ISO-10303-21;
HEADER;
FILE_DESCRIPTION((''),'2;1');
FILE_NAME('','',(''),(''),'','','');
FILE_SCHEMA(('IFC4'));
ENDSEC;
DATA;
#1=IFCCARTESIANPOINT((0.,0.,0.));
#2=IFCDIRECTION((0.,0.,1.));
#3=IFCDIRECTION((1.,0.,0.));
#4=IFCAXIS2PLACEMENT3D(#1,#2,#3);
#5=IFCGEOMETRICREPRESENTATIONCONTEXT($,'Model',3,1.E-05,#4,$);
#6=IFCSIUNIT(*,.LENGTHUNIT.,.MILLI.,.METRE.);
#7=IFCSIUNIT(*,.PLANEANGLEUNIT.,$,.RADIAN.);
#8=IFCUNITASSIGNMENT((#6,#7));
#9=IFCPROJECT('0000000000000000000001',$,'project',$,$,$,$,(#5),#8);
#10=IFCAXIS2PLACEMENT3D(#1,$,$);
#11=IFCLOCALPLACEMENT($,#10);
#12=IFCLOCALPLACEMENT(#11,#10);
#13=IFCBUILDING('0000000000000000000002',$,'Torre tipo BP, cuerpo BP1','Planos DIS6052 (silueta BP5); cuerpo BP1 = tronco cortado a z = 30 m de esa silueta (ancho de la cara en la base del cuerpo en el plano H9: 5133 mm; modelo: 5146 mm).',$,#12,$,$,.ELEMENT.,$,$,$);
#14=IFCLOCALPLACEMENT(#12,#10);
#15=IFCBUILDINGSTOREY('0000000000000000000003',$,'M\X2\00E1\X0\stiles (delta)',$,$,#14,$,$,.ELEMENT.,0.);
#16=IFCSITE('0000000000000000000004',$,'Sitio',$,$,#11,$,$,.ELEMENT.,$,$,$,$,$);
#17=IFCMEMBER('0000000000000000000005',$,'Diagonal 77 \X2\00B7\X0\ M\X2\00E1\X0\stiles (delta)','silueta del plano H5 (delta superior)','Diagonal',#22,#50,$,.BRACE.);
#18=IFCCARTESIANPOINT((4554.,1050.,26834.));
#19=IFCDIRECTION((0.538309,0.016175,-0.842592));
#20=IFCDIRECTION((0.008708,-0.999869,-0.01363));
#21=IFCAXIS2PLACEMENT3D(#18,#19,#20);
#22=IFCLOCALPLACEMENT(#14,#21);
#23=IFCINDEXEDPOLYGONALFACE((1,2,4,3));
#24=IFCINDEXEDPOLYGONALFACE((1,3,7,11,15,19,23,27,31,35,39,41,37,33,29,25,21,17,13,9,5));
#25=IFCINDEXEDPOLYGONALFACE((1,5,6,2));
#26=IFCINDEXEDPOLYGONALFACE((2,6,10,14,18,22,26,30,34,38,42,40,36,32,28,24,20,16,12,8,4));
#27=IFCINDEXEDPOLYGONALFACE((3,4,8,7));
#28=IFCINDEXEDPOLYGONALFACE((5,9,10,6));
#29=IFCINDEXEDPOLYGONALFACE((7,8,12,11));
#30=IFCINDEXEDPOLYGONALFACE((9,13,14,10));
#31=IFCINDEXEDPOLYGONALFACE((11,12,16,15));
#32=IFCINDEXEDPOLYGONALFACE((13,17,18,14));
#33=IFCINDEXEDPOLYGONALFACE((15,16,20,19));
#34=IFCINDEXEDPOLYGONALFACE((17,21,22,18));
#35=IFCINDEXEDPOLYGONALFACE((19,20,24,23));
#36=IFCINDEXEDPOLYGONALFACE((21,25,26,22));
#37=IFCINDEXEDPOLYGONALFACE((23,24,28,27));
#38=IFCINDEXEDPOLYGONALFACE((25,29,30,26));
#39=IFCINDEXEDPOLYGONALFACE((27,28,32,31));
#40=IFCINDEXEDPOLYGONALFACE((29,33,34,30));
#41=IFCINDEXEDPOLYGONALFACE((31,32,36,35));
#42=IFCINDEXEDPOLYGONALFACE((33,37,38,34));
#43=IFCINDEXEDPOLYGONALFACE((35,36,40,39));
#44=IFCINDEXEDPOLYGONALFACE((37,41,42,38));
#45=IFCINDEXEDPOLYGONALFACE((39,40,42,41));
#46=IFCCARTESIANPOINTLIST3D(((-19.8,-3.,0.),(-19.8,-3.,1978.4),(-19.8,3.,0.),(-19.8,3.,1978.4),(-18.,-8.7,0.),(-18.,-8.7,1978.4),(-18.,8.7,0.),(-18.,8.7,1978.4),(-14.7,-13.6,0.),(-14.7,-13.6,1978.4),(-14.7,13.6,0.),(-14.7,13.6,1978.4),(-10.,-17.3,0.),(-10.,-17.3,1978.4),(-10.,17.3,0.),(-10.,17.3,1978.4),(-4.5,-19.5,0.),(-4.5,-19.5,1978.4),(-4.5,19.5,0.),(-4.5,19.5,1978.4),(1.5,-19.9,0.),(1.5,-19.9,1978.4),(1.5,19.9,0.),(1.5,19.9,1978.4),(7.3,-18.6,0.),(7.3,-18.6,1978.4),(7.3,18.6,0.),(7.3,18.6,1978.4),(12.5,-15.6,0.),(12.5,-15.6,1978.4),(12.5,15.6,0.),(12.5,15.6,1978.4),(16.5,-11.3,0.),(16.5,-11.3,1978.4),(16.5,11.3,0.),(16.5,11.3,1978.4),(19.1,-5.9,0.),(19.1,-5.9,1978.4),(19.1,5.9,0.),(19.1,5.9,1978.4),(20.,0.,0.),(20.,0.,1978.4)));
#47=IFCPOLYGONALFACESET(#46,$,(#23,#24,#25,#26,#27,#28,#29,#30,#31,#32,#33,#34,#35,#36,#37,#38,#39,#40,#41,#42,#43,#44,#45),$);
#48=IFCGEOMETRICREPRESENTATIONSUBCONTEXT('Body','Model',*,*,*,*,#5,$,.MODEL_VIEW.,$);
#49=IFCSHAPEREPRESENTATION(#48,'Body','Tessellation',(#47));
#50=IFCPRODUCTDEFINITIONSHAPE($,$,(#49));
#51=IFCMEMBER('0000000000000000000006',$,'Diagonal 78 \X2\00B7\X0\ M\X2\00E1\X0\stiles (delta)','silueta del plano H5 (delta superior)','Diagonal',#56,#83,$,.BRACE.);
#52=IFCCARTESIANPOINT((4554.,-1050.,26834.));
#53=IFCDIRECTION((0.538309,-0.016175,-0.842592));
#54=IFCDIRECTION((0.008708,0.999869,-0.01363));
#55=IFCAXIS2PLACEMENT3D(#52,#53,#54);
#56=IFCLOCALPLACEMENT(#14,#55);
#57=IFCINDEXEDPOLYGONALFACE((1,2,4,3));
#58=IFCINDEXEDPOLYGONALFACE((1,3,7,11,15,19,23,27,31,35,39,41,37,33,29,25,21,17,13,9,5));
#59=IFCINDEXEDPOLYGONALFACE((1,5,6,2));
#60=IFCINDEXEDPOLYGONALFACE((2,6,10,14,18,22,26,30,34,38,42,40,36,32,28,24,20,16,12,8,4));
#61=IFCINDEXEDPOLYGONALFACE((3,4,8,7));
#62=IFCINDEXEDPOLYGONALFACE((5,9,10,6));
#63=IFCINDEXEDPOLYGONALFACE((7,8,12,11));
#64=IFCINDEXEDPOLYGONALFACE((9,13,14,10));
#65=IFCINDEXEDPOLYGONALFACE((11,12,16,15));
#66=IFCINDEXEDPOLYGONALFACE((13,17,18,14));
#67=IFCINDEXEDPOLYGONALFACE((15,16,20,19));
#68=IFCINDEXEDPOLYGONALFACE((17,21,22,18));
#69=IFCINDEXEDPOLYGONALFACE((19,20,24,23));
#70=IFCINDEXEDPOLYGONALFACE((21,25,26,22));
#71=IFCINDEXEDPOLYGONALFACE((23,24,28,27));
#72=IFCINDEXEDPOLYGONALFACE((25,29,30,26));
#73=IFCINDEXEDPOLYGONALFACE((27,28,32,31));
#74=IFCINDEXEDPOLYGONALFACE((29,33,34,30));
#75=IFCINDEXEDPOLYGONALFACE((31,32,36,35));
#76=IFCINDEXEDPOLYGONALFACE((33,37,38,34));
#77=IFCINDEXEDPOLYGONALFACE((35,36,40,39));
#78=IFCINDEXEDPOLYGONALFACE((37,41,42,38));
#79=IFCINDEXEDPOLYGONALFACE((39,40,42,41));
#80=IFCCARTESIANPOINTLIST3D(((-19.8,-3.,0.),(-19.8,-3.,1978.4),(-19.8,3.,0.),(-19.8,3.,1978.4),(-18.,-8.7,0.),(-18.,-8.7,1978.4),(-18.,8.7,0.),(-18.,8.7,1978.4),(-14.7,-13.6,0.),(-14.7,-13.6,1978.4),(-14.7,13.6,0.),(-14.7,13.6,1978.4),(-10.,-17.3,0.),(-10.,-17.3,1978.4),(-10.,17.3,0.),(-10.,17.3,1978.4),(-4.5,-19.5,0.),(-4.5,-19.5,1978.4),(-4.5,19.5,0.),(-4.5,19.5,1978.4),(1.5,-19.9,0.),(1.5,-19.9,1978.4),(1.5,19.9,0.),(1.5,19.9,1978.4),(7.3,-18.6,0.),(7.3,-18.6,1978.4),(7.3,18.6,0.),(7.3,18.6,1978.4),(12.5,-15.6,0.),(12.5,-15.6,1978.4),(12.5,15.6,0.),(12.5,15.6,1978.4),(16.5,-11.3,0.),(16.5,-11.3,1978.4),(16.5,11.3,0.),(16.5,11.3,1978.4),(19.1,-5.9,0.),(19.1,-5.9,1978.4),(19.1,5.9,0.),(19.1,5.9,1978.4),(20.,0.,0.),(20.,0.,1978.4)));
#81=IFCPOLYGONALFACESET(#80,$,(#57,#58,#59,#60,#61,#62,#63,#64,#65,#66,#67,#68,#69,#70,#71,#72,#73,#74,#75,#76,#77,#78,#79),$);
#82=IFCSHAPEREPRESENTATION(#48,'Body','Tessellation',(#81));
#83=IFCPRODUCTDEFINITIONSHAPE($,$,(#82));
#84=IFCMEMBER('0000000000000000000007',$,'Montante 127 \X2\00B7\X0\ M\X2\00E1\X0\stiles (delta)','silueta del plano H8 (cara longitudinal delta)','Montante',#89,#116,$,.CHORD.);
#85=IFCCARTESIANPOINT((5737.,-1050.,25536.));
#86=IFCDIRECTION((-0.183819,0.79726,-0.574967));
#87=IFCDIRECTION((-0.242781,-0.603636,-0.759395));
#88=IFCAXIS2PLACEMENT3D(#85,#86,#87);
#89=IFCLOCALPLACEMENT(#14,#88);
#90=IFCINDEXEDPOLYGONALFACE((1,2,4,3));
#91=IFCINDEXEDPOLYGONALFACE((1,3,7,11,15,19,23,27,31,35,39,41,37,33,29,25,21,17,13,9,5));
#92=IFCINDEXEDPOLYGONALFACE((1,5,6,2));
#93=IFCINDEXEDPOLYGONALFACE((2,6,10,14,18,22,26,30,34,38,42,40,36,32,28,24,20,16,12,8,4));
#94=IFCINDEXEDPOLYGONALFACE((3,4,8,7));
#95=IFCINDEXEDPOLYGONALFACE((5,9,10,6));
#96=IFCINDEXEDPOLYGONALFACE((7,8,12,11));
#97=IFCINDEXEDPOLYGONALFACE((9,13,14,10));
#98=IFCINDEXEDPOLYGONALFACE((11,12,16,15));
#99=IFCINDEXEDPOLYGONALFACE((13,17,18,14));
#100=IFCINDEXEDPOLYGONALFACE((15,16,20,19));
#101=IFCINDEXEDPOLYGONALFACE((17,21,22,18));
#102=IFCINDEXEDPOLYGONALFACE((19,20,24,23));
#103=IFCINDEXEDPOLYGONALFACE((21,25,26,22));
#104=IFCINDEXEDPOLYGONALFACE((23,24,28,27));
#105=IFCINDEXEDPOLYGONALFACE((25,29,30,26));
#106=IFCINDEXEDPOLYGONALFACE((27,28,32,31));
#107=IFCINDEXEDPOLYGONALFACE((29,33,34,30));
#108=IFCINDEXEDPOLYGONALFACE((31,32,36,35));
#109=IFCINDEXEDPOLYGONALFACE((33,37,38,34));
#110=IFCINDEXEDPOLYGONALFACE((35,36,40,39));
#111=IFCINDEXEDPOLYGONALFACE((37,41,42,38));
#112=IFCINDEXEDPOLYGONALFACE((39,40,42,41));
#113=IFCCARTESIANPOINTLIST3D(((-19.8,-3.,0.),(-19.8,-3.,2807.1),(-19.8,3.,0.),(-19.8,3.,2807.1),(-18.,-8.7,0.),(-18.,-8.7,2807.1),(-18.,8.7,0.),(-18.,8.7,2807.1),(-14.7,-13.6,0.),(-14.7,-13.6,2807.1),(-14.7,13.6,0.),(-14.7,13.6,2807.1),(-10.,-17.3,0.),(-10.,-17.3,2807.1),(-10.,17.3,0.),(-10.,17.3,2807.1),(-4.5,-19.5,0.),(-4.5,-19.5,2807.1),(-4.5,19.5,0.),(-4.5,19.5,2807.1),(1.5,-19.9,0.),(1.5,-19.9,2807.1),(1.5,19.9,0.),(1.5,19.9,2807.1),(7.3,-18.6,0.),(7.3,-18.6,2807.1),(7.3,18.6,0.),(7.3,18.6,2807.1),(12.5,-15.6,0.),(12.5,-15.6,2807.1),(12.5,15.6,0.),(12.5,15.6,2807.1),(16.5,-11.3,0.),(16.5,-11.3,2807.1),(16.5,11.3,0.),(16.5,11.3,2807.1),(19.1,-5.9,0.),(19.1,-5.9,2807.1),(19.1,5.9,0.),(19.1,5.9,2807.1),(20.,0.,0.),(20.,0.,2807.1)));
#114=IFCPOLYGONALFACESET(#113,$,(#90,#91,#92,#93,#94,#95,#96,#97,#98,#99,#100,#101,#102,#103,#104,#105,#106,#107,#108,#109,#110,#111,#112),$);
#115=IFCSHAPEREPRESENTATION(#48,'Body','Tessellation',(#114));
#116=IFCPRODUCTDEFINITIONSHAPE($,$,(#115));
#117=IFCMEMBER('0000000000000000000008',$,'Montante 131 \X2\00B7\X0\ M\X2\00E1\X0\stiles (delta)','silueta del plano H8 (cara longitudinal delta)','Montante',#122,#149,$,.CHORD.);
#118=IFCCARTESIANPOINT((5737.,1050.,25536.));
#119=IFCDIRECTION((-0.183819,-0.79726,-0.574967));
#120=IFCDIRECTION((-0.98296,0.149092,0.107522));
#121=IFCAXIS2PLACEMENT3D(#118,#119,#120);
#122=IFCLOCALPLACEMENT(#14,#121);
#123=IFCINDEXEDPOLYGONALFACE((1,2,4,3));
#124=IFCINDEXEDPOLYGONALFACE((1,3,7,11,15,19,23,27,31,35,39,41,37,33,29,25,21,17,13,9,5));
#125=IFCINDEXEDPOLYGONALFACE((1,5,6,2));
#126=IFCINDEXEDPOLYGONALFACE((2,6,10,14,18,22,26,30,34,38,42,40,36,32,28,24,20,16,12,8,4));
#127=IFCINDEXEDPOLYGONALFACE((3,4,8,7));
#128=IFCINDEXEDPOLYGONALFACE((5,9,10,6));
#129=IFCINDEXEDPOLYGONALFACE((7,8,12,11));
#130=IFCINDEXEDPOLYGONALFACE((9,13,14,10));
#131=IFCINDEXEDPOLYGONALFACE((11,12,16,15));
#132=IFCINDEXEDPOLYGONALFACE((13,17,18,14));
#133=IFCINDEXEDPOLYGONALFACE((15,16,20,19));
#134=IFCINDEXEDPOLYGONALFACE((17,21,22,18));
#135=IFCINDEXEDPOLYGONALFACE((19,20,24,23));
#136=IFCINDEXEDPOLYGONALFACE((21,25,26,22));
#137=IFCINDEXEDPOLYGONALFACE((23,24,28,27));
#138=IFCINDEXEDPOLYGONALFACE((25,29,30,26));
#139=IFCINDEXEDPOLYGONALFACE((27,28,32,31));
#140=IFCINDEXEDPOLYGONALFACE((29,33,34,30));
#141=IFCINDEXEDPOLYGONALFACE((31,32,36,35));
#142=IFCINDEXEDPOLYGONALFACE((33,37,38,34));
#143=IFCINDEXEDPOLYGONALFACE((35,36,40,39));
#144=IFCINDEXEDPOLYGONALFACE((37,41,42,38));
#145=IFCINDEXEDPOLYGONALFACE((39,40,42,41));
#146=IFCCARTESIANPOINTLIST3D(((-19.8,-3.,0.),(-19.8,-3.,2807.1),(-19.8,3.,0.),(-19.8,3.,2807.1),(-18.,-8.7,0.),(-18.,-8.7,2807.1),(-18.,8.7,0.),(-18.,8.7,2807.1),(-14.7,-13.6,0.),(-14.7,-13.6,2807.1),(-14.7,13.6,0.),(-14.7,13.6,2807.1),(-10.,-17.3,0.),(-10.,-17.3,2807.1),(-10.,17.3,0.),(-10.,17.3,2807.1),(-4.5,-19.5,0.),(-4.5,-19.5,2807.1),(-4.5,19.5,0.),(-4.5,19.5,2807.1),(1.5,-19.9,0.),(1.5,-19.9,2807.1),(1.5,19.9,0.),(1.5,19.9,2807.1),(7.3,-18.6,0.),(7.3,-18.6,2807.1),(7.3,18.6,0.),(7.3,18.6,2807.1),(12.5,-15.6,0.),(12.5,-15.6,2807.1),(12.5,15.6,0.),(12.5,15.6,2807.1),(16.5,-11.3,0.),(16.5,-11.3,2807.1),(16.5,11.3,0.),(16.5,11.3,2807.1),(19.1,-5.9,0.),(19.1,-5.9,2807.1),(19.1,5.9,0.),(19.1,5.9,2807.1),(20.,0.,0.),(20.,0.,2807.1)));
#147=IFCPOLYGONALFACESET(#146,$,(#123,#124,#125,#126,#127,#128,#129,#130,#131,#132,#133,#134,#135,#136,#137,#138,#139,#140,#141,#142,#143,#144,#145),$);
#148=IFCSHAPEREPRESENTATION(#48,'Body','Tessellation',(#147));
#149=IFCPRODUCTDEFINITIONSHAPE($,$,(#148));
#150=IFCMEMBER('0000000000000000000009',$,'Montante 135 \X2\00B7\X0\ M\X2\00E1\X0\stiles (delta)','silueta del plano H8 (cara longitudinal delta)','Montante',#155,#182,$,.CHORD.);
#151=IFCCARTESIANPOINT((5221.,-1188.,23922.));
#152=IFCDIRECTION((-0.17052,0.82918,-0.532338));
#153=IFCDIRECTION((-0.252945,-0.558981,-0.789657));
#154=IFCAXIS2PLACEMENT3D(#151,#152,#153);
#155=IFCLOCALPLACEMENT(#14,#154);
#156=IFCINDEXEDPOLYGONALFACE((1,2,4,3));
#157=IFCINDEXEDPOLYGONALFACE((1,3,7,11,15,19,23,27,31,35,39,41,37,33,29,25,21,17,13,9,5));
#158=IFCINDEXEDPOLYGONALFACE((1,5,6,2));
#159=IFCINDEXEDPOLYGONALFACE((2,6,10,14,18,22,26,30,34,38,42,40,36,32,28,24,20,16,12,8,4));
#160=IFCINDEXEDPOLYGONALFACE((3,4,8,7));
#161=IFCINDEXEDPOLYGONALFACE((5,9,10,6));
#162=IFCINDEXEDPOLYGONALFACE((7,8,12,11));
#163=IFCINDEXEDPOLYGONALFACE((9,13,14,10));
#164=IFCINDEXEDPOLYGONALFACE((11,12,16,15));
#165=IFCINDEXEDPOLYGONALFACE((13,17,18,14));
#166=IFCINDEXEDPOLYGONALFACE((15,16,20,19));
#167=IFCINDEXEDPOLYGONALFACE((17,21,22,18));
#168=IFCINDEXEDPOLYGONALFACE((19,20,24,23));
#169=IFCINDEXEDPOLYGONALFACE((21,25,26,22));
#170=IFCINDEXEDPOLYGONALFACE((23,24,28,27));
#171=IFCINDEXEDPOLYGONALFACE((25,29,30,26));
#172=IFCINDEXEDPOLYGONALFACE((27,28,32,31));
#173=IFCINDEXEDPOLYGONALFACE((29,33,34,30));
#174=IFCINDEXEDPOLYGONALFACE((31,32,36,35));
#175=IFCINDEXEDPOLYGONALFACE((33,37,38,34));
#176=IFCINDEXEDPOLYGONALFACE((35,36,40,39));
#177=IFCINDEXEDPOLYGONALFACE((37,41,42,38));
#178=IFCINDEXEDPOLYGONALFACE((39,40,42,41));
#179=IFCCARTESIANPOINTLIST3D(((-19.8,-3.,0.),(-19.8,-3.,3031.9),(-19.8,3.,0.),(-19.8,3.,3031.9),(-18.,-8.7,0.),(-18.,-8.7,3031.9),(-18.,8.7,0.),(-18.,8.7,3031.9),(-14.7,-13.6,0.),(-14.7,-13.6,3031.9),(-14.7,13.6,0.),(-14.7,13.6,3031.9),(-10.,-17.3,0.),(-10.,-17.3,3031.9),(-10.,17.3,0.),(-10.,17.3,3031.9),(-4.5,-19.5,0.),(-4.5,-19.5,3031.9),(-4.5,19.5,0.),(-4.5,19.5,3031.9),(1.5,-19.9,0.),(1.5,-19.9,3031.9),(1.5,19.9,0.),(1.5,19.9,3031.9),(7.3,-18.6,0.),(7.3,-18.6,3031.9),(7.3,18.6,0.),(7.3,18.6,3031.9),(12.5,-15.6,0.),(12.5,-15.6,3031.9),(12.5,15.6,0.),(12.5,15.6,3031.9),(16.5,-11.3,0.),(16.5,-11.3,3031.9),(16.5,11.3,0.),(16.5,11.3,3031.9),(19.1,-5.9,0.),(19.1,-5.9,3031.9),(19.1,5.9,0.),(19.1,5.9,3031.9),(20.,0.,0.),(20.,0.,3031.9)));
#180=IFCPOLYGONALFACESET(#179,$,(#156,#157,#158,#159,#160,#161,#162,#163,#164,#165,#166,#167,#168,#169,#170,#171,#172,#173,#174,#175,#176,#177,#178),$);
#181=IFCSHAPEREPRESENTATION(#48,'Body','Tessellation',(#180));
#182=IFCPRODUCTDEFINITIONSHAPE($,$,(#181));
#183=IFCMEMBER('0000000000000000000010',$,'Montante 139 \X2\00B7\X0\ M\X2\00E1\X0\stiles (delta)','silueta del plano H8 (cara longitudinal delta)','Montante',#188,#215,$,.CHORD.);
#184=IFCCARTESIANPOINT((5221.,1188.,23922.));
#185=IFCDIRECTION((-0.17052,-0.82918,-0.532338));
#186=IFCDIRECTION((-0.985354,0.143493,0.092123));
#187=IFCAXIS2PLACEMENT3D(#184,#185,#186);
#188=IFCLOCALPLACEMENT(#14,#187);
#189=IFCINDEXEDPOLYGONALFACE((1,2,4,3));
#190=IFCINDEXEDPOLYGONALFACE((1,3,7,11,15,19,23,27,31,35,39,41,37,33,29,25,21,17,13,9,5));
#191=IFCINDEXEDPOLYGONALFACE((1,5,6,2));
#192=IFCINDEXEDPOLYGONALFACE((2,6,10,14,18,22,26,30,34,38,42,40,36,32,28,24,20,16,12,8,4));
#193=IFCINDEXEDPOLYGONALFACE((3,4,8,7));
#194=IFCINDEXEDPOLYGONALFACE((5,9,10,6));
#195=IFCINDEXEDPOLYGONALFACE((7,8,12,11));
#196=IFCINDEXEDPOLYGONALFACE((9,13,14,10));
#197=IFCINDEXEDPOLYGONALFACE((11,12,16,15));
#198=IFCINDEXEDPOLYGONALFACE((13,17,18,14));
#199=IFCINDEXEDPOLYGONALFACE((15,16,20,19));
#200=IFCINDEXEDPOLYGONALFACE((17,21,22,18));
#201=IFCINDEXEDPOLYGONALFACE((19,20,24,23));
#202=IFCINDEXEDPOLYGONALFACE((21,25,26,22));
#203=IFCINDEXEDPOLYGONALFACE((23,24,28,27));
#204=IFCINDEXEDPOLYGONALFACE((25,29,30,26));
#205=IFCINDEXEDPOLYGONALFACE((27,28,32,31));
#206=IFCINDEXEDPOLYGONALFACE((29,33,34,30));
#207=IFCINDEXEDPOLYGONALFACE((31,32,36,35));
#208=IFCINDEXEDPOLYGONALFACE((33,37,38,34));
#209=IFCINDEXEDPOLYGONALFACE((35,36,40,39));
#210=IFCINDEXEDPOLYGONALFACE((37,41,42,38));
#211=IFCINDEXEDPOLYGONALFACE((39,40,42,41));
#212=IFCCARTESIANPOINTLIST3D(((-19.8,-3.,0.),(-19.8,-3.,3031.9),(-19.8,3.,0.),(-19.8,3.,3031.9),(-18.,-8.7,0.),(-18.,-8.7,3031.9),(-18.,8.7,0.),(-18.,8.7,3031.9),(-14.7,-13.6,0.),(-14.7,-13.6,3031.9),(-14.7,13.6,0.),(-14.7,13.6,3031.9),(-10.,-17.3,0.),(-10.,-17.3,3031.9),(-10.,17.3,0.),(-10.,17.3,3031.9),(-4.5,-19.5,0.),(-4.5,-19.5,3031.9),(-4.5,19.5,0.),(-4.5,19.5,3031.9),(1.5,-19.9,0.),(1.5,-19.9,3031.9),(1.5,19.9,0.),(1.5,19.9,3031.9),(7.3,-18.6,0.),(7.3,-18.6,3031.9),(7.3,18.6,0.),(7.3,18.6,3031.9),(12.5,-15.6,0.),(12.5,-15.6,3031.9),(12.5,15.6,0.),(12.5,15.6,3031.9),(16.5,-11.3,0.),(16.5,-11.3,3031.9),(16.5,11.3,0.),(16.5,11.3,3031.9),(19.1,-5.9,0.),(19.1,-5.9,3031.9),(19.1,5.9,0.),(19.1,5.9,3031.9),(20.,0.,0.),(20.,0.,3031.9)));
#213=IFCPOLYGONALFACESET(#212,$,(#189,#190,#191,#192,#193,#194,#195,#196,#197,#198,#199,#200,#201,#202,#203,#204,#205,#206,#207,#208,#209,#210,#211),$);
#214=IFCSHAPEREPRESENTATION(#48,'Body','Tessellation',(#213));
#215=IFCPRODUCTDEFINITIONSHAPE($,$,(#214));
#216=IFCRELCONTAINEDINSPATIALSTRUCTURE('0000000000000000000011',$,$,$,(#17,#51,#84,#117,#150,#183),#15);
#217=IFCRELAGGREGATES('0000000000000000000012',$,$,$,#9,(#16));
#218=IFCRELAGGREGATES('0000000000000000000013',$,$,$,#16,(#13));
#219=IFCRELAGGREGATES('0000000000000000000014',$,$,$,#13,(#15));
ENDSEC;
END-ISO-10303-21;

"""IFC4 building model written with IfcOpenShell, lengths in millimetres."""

from ifc_helpers import new_model, si_unit, frame, origin, origin_with_axes, place, context, subcontext, project, spatial, circle, extrude, element, save


model = new_model("IFC4")

# Units and contexts
model_context = context("Model", 3, precision=1e-05, world=origin_with_axes())
body_context = subcontext(model_context, "Body", "Model", "MODEL_VIEW")
ifc_project = project(units=[si_unit("LENGTHUNIT", "METRE", prefix="MILLI"), si_unit("PLANEANGLEUNIT", "RADIAN")], contexts=[model_context])

# Site, building, storey
site_placement = place(None, origin())
site = spatial("IfcSite", under=ifc_project, at=site_placement, Name="Sitio", CompositionType="ELEMENT")
building_placement = place(site_placement, origin())
building = spatial("IfcBuilding", under=site, at=building_placement, Name="Torre tipo BP, cuerpo BP1", Description="Planos DIS6052 (silueta BP5); cuerpo BP1 = tronco cortado a z = 30 m de esa silueta (ancho de la cara en la base del cuerpo en el plano H9: 5133 mm; modelo: 5146 mm).", CompositionType="ELEMENT")
storey_placement = place(building_placement, origin())
storey = spatial("IfcBuildingStorey", under=building, at=storey_placement, Name="Mástiles (delta)", CompositionType="ELEMENT", Elevation=0.0)

# Members
for number, where, z_axis, x_axis, name in (
    (1, (4554.0, 1050.0, 26834.0), (0.538309, 0.016175, -0.842592), (0.008708, -0.999869, -0.01363), "Diagonal 77 · Mástiles (delta)"),
    (2, (4554.0, -1050.0, 26834.0), (0.538309, -0.016175, -0.842592), (0.008708, 0.999869, -0.01363), "Diagonal 78 · Mástiles (delta)"),
):
    element("IfcMember", number, at=place(storey_placement, frame(where, z_axis=z_axis, x_axis=x_axis)), inside=storey, Name=name, Description="silueta del plano H5 (delta superior)", ObjectType="Diagonal", PredefinedType="BRACE", context=body_context, shape_type="SweptSolid", body=[
        extrude(circle(Radius=20.0), None, (0.0, 0.0, 1.0), 1978.4),
    ])
for number, where, z_axis, x_axis, name in (
    (3, (5737.0, -1050.0, 25536.0), (-0.183819, 0.79726, -0.574967), (-0.242781, -0.603636, -0.759395), "Montante 127 · Mástiles (delta)"),
    (4, (5737.0, 1050.0, 25536.0), (-0.183819, -0.79726, -0.574967), (-0.98296, 0.149092, 0.107522), "Montante 131 · Mástiles (delta)"),
):
    element("IfcMember", number, at=place(storey_placement, frame(where, z_axis=z_axis, x_axis=x_axis)), inside=storey, Name=name, Description="silueta del plano H8 (cara longitudinal delta)", ObjectType="Montante", PredefinedType="CHORD", context=body_context, shape_type="SweptSolid", body=[
        extrude(circle(Radius=20.0), None, (0.0, 0.0, 1.0), 2807.1),
    ])
for number, where, z_axis, x_axis, name in (
    (5, (5221.0, -1188.0, 23922.0), (-0.17052, 0.82918, -0.532338), (-0.252945, -0.558981, -0.789657), "Montante 135 · Mástiles (delta)"),
    (6, (5221.0, 1188.0, 23922.0), (-0.17052, -0.82918, -0.532338), (-0.985354, 0.143493, 0.092123), "Montante 139 · Mástiles (delta)"),
):
    element("IfcMember", number, at=place(storey_placement, frame(where, z_axis=z_axis, x_axis=x_axis)), inside=storey, Name=name, Description="silueta del plano H8 (cara longitudinal delta)", ObjectType="Montante", PredefinedType="CHORD", context=body_context, shape_type="SweptSolid", body=[
        extrude(circle(Radius=20.0), None, (0.0, 0.0, 1.0), 3031.9),
    ])

save(model, "model.ifc")
